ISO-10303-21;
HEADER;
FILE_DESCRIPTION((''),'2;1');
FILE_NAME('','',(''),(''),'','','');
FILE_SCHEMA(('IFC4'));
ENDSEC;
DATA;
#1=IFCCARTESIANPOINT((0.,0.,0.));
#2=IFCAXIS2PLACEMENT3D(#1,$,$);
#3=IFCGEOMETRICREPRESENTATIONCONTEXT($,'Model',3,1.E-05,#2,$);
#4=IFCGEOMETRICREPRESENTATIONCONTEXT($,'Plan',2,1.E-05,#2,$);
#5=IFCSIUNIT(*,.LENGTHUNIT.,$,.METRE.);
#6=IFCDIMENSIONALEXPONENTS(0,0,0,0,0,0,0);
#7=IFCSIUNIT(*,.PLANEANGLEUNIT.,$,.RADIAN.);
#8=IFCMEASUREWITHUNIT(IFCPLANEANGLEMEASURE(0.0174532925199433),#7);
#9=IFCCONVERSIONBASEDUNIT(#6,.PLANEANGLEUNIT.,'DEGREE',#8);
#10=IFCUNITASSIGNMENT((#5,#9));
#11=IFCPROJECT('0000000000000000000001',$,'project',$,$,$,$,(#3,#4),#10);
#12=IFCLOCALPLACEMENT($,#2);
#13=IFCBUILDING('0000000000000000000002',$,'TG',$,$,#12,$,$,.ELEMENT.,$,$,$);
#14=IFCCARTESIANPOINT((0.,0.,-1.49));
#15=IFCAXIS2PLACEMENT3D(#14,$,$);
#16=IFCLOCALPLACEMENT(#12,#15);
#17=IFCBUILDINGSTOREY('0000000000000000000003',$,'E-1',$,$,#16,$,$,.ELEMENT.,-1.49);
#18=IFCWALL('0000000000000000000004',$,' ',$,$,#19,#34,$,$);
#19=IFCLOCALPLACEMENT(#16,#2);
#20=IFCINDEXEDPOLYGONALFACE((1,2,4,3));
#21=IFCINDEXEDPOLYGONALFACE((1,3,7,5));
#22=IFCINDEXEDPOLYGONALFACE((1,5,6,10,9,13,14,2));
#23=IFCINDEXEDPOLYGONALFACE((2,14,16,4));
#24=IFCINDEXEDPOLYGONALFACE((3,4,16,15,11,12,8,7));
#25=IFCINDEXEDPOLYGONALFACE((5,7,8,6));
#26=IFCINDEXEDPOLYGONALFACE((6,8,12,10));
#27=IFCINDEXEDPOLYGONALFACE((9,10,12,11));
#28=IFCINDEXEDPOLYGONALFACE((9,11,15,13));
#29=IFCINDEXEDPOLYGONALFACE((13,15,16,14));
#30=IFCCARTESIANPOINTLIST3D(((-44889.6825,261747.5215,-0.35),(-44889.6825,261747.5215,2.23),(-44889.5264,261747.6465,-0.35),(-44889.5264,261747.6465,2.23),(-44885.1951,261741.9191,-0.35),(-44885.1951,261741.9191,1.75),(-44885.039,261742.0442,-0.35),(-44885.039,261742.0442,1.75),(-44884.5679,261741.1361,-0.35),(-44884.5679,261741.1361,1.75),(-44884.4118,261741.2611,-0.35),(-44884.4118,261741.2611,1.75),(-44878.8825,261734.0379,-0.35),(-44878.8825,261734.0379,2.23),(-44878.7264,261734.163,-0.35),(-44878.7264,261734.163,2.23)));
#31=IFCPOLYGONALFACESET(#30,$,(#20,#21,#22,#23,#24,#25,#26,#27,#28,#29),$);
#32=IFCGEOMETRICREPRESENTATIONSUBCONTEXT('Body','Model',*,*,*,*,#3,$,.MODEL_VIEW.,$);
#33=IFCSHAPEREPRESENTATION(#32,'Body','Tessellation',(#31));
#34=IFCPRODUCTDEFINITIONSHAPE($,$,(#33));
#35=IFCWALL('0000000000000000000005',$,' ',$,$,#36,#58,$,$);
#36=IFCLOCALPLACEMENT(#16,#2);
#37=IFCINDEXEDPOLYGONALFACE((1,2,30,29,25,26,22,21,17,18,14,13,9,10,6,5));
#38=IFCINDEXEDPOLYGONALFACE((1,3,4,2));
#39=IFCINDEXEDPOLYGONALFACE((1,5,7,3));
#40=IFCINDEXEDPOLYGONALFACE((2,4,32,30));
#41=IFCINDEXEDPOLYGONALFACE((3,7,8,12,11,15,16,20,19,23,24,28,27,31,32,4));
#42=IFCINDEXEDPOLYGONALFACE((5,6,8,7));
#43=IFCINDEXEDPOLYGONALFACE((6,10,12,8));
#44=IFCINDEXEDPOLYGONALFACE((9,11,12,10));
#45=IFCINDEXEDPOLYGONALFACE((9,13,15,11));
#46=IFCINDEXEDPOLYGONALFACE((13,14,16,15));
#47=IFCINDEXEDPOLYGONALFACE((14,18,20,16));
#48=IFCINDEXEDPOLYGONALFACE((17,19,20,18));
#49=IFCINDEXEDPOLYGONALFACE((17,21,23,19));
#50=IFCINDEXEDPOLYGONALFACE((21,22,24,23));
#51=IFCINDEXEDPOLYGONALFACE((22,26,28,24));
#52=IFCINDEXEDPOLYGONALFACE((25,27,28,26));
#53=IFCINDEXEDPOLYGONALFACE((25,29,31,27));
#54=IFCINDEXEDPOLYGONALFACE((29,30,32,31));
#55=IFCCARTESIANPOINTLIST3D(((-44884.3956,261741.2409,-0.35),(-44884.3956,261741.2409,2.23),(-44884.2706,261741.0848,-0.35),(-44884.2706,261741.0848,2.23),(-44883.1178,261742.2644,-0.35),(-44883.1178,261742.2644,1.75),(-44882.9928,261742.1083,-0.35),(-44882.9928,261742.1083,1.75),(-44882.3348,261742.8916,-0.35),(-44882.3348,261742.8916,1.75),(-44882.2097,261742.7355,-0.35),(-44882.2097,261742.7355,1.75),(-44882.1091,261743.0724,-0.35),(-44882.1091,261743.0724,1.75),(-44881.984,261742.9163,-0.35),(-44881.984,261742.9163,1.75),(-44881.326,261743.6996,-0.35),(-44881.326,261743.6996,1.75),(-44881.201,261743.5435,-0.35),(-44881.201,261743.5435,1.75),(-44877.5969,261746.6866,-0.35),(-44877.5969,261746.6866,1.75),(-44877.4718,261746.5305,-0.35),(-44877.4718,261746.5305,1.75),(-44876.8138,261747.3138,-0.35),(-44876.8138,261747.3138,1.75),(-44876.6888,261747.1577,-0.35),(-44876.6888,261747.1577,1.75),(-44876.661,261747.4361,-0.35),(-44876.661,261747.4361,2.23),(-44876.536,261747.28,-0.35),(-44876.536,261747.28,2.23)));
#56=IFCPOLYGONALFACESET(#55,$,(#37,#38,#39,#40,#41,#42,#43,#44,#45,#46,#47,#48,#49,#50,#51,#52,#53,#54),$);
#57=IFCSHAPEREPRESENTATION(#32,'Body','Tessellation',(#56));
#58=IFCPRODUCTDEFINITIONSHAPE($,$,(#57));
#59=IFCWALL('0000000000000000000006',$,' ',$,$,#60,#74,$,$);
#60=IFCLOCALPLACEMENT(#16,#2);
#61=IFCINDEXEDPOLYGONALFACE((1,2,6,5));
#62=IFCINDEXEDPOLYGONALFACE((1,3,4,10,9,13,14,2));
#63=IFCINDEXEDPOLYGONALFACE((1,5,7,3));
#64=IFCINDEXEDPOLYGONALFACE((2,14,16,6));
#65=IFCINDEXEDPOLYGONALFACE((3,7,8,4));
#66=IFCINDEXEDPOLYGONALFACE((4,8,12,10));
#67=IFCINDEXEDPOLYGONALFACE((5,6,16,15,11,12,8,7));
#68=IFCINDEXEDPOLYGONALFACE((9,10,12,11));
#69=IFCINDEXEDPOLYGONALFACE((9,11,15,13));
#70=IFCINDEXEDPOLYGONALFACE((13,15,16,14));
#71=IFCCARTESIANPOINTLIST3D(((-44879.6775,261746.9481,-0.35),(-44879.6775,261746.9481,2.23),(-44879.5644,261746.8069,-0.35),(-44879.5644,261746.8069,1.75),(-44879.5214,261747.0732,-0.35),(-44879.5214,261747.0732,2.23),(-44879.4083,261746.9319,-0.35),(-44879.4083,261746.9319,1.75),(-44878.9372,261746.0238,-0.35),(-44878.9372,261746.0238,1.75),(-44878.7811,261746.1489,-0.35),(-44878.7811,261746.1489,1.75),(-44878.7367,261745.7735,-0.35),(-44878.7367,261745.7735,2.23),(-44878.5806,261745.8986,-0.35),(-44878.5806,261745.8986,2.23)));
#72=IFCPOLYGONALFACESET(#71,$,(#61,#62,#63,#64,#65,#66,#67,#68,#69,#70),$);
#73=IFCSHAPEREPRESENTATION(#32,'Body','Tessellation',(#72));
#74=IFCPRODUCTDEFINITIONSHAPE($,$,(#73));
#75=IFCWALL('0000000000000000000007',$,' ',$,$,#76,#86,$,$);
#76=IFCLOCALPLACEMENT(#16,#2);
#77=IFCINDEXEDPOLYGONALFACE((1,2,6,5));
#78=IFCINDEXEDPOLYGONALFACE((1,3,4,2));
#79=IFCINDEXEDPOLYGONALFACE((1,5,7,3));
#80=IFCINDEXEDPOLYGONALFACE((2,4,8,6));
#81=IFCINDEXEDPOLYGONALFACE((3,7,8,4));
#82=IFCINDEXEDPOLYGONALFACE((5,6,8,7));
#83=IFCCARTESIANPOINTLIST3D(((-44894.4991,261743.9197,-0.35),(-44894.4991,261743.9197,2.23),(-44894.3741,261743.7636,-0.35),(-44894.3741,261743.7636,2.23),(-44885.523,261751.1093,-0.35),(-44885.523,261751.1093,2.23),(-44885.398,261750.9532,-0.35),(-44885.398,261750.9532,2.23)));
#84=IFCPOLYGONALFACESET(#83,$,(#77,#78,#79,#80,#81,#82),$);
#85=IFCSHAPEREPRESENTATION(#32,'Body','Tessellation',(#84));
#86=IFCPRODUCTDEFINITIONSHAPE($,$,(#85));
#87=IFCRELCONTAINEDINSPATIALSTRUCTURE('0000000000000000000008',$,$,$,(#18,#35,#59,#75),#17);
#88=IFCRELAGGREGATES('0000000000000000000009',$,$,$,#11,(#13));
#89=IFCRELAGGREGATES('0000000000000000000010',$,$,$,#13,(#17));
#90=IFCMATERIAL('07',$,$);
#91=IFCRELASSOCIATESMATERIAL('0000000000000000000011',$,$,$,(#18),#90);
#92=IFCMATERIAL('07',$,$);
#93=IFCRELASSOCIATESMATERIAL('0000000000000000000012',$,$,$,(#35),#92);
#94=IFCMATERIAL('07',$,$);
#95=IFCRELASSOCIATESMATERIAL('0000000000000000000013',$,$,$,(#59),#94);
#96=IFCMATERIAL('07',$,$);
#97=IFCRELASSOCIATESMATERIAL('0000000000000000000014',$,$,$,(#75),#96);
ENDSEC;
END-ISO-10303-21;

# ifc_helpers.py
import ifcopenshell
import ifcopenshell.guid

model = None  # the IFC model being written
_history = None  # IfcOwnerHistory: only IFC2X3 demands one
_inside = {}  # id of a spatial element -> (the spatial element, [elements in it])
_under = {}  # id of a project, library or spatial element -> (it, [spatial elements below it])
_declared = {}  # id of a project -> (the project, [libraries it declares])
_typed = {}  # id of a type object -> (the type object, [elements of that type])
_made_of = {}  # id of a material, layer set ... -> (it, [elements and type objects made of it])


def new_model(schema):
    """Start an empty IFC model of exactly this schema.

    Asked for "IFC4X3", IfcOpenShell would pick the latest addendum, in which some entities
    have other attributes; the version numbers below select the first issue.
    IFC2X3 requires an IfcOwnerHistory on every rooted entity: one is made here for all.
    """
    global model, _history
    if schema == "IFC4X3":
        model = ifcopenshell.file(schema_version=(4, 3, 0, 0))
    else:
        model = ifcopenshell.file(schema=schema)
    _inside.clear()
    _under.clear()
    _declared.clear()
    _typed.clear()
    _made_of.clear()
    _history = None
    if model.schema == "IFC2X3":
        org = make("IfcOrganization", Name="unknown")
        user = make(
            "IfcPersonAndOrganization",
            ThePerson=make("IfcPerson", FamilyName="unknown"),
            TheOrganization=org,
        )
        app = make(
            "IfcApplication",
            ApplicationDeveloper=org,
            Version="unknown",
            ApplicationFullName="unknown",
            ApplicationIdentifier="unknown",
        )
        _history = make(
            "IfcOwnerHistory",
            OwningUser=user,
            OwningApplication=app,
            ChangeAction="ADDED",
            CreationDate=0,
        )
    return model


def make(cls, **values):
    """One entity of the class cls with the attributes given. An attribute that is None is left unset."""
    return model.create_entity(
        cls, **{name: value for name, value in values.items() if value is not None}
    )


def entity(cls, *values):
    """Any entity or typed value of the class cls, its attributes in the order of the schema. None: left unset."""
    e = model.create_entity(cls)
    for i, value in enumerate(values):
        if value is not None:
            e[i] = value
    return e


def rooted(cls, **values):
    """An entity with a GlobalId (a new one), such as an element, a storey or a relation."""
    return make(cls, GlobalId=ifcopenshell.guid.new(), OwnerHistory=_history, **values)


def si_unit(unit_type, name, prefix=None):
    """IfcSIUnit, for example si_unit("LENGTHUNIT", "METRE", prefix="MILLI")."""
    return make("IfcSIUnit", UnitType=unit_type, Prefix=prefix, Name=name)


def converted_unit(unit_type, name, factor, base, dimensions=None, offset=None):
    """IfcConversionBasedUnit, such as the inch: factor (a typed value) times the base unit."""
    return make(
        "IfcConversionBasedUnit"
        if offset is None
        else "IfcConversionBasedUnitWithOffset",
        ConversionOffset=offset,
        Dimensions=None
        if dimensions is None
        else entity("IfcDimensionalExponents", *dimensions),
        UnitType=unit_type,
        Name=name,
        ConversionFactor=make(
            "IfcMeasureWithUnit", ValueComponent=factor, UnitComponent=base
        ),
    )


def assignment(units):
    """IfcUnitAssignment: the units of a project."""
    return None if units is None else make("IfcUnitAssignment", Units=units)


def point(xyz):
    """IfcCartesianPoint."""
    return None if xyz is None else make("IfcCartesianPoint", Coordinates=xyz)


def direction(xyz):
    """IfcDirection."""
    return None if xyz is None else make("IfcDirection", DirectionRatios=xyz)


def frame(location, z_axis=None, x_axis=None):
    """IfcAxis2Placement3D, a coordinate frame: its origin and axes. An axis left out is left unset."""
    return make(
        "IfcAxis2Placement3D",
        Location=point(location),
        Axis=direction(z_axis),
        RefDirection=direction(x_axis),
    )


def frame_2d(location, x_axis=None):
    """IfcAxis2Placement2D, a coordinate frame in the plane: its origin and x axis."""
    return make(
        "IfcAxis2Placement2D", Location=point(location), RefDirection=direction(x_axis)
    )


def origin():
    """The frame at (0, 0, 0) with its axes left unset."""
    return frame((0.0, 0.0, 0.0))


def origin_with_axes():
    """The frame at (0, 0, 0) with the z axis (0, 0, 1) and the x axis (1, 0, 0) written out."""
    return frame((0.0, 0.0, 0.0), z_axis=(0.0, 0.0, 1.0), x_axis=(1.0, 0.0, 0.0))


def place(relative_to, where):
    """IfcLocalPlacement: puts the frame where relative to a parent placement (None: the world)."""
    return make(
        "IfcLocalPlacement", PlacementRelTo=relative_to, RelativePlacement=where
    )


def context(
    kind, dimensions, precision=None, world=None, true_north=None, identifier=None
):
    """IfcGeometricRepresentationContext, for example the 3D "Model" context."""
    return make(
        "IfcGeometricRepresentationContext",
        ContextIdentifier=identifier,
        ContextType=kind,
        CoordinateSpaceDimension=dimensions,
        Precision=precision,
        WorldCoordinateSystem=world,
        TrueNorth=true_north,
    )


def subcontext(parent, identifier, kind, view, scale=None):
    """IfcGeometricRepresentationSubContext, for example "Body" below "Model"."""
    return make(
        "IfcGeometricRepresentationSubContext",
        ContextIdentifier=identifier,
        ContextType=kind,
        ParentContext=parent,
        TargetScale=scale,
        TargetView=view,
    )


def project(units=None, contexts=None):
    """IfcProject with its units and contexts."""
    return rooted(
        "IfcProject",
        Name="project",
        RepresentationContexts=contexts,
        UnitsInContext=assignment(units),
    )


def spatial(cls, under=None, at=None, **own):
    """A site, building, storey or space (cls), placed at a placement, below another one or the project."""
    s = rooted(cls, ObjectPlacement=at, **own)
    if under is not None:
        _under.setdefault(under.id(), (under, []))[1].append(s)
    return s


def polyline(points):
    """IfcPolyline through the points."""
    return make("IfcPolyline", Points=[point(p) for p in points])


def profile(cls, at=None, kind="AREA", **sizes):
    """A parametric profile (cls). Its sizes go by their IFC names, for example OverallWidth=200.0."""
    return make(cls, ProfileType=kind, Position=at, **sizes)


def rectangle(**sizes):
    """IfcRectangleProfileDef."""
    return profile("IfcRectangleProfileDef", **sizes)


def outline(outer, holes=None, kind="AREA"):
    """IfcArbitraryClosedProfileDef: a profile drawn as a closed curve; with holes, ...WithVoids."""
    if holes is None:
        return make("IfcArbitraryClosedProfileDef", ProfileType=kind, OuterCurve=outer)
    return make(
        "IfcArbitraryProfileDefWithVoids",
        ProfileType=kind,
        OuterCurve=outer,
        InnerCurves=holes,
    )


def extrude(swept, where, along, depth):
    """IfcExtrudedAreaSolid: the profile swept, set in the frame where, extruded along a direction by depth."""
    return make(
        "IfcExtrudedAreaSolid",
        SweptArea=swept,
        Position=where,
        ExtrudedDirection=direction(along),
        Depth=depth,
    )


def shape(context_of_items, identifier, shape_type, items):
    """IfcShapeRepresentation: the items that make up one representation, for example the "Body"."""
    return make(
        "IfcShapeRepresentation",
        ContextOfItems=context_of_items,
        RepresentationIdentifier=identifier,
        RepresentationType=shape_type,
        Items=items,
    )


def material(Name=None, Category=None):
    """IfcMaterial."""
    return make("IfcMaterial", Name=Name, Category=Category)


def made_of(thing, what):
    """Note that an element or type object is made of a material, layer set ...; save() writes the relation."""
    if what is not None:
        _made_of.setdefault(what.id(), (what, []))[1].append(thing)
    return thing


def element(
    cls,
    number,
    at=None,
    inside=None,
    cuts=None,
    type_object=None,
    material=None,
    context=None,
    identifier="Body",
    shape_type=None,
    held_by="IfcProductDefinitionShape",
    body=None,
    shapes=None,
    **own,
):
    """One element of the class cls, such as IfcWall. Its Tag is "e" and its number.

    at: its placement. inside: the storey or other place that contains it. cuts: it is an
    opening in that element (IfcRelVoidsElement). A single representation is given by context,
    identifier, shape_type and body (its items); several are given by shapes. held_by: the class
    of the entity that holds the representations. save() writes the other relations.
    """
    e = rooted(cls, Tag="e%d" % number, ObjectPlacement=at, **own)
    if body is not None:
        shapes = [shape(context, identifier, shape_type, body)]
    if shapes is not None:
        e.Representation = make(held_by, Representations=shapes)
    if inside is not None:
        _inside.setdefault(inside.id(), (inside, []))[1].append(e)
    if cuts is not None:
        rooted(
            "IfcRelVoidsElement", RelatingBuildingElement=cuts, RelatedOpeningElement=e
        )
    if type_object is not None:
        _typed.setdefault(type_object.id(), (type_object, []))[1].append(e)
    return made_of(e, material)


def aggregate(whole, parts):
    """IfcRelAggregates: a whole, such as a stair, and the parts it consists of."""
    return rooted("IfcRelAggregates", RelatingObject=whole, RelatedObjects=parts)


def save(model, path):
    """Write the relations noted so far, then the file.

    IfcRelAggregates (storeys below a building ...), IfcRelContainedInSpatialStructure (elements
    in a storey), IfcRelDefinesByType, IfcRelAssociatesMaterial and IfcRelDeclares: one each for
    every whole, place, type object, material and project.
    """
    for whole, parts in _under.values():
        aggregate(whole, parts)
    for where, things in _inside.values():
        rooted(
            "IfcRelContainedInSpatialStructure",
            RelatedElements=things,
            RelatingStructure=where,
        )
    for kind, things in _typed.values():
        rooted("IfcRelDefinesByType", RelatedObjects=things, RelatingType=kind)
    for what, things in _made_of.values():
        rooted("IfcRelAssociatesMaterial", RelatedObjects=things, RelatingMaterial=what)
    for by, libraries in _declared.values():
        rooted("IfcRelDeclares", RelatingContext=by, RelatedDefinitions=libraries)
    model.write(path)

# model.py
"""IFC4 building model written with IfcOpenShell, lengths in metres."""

from ifc_helpers import new_model, entity, si_unit, converted_unit, frame, frame_2d, origin, origin_with_axes, place, context, subcontext, project, spatial, polyline, rectangle, outline, extrude, material, element, save


model = new_model("IFC4")

# Units and contexts
model_context = context("Model", 3, precision=1e-05, world=origin())
plan_context = context("Plan", 2, precision=1e-05, world=origin())
body_context = subcontext(model_context, "Body", "Model", "MODEL_VIEW")
ifc_project = project(units=[si_unit("LENGTHUNIT", "METRE"), converted_unit("PLANEANGLEUNIT", "DEGREE", entity("IfcPlaneAngleMeasure", 0.0174532925199433), si_unit("PLANEANGLEUNIT", "RADIAN"), dimensions=[0, 0, 0, 0, 0, 0, 0])], contexts=[model_context, plan_context])

# Building, storey
building_placement = place(None, origin())
building = spatial("IfcBuilding", under=ifc_project, at=building_placement, Name="TG", CompositionType="ELEMENT")
storey_placement = place(building_placement, frame((0.0, 0.0, -1.49)))
storey = spatial("IfcBuildingStorey", under=building, at=storey_placement, Name="E-1", CompositionType="ELEMENT", Elevation=-1.49)

# Wall, opening
ifc_material_1 = material(Name="07")
wall_1_placement = place(storey_placement, frame((-44889.6825, 261747.5215, -0.35), z_axis=(0.0, 0.0, 1.0), x_axis=(0.625159, -0.780498, 0.0)))
wall_1 = element("IfcWall", 1, at=wall_1_placement, inside=storey, material=ifc_material_1, Name=" ", context=body_context, shape_type="SweptSolid", body=[
    extrude(rectangle(XDim=17.2756, YDim=0.2, at=frame_2d((8.6378, 0.1), x_axis=(1.0, 0.0))), origin_with_axes(), (0.0, 0.0, 1.0), 2.58),
])
opening_1_placement = place(wall_1_placement, frame((8.1812, 0.2, 0.0), z_axis=(0.0, -1.0, 0.0), x_axis=(0.0, 0.0, 1.0)))
element("IfcOpeningElement", 2, at=opening_1_placement, cuts=wall_1, ObjectType="Opening", context=body_context, shape_type="SweptSolid", body=[
    extrude(outline(polyline([(0.0, 1.0033), (2.1, 1.0033), (2.1, 0.0), (0.0, 0.0), (0.0, 1.0033)])), origin_with_axes(), (0.0, 0.0, 1.0), 0.2),
])

# Wall, openings
ifc_material_2 = material(Name="07")
wall_2_placement = place(storey_placement, frame((-44884.2706, 261741.0848, -0.35), z_axis=(0.0, 0.0, 1.0), x_axis=(0.780498, 0.625159, 0.0)))
wall_2 = element("IfcWall", 3, at=wall_2_placement, inside=storey, material=ifc_material_2, Name=" ", context=body_context, shape_type="SweptSolid", body=[
    extrude(rectangle(XDim=9.9098, YDim=0.2, at=frame_2d((4.9549, 0.1), x_axis=(1.0, 0.0))), origin_with_axes(), (0.0, 0.0, 1.0), 2.58),
])
opening_2_placement = place(wall_2_placement, frame((2.6405, 0.2, 0.0), z_axis=(0.0, -1.0, 0.0), x_axis=(0.0, 0.0, 1.0)))
element("IfcOpeningElement", 4, at=opening_2_placement, cuts=wall_2, ObjectType="Opening", context=body_context, shape_type="SweptSolid", body=[
    extrude(outline(polyline([(0.0, 1.0033), (2.1, 1.0033), (2.1, 0.0), (0.0, 0.0), (0.0, 1.0033)])), origin_with_axes(), (0.0, 0.0, 1.0), 0.2),
])
opening_3_placement = place(wall_2_placement, frame((3.9329, 0.2, 0.0), z_axis=(0.0, -1.0, 0.0), x_axis=(0.0, 0.0, 1.0)))
element("IfcOpeningElement", 5, at=opening_3_placement, cuts=wall_2, ObjectType="Opening", context=body_context, shape_type="SweptSolid", body=[
    extrude(outline(polyline([(0.0, 1.0033), (2.1, 1.0033), (2.1, 0.0), (0.0, 0.0), (0.0, 1.0033)])), origin_with_axes(), (0.0, 0.0, 1.0), 0.2),
])
opening_4_placement = place(wall_2_placement, frame((9.7141, 0.2, 0.0), z_axis=(0.0, -1.0, 0.0), x_axis=(0.0, 0.0, 1.0)))
element("IfcOpeningElement", 6, at=opening_4_placement, cuts=wall_2, ObjectType="Opening", context=body_context, shape_type="SweptSolid", body=[
    extrude(outline(polyline([(0.0, 1.0033), (2.1, 1.0033), (2.1, 0.0), (0.0, 0.0), (0.0, 1.0033)])), origin_with_axes(), (0.0, 0.0, 1.0), 0.2),
])

# Wall, opening
ifc_material_3 = material(Name="07")
wall_3_placement = place(storey_placement, frame((-44879.6775, 261746.9481, -0.35), z_axis=(0.0, 0.0, 1.0), x_axis=(0.625159, -0.780498, 0.0)))
wall_3 = element("IfcWall", 7, at=wall_3_placement, inside=storey, material=ifc_material_3, Name=" ", context=body_context, shape_type="SweptSolid", body=[
    extrude(rectangle(XDim=1.5049, YDim=0.2, at=frame_2d((0.7525, 0.1), x_axis=(1.0, 0.0))), origin_with_axes(), (0.0, 0.0, 1.0), 2.58),
])
opening_5_placement = place(wall_3_placement, frame((1.1842, 0.2, 0.0), z_axis=(0.0, -1.0, 0.0), x_axis=(0.0, 0.0, 1.0)))
element("IfcOpeningElement", 8, at=opening_5_placement, cuts=wall_3, ObjectType="Opening", context=body_context, shape_type="SweptSolid", body=[
    extrude(outline(polyline([(0.0, 1.0033), (2.1, 1.0033), (2.1, 0.0), (0.0, 0.0), (0.0, 1.0033)])), origin_with_axes(), (0.0, 0.0, 1.0), 0.2),
])

# Wall
ifc_material_4 = material(Name="07")
wall_4_placement = place(storey_placement, frame((-44894.3741, 261743.7636, -0.35), z_axis=(0.0, 0.0, 1.0), x_axis=(0.780498, 0.625159, 0.0)))
element("IfcWall", 9, at=wall_4_placement, inside=storey, material=ifc_material_4, Name=" ", context=body_context, shape_type="SweptSolid", body=[
    extrude(rectangle(XDim=11.5005, YDim=0.2, at=frame_2d((5.7502, 0.1), x_axis=(1.0, 0.0))), origin_with_axes(), (0.0, 0.0, 1.0), 2.58),
])

save(model, "model.ifc")
